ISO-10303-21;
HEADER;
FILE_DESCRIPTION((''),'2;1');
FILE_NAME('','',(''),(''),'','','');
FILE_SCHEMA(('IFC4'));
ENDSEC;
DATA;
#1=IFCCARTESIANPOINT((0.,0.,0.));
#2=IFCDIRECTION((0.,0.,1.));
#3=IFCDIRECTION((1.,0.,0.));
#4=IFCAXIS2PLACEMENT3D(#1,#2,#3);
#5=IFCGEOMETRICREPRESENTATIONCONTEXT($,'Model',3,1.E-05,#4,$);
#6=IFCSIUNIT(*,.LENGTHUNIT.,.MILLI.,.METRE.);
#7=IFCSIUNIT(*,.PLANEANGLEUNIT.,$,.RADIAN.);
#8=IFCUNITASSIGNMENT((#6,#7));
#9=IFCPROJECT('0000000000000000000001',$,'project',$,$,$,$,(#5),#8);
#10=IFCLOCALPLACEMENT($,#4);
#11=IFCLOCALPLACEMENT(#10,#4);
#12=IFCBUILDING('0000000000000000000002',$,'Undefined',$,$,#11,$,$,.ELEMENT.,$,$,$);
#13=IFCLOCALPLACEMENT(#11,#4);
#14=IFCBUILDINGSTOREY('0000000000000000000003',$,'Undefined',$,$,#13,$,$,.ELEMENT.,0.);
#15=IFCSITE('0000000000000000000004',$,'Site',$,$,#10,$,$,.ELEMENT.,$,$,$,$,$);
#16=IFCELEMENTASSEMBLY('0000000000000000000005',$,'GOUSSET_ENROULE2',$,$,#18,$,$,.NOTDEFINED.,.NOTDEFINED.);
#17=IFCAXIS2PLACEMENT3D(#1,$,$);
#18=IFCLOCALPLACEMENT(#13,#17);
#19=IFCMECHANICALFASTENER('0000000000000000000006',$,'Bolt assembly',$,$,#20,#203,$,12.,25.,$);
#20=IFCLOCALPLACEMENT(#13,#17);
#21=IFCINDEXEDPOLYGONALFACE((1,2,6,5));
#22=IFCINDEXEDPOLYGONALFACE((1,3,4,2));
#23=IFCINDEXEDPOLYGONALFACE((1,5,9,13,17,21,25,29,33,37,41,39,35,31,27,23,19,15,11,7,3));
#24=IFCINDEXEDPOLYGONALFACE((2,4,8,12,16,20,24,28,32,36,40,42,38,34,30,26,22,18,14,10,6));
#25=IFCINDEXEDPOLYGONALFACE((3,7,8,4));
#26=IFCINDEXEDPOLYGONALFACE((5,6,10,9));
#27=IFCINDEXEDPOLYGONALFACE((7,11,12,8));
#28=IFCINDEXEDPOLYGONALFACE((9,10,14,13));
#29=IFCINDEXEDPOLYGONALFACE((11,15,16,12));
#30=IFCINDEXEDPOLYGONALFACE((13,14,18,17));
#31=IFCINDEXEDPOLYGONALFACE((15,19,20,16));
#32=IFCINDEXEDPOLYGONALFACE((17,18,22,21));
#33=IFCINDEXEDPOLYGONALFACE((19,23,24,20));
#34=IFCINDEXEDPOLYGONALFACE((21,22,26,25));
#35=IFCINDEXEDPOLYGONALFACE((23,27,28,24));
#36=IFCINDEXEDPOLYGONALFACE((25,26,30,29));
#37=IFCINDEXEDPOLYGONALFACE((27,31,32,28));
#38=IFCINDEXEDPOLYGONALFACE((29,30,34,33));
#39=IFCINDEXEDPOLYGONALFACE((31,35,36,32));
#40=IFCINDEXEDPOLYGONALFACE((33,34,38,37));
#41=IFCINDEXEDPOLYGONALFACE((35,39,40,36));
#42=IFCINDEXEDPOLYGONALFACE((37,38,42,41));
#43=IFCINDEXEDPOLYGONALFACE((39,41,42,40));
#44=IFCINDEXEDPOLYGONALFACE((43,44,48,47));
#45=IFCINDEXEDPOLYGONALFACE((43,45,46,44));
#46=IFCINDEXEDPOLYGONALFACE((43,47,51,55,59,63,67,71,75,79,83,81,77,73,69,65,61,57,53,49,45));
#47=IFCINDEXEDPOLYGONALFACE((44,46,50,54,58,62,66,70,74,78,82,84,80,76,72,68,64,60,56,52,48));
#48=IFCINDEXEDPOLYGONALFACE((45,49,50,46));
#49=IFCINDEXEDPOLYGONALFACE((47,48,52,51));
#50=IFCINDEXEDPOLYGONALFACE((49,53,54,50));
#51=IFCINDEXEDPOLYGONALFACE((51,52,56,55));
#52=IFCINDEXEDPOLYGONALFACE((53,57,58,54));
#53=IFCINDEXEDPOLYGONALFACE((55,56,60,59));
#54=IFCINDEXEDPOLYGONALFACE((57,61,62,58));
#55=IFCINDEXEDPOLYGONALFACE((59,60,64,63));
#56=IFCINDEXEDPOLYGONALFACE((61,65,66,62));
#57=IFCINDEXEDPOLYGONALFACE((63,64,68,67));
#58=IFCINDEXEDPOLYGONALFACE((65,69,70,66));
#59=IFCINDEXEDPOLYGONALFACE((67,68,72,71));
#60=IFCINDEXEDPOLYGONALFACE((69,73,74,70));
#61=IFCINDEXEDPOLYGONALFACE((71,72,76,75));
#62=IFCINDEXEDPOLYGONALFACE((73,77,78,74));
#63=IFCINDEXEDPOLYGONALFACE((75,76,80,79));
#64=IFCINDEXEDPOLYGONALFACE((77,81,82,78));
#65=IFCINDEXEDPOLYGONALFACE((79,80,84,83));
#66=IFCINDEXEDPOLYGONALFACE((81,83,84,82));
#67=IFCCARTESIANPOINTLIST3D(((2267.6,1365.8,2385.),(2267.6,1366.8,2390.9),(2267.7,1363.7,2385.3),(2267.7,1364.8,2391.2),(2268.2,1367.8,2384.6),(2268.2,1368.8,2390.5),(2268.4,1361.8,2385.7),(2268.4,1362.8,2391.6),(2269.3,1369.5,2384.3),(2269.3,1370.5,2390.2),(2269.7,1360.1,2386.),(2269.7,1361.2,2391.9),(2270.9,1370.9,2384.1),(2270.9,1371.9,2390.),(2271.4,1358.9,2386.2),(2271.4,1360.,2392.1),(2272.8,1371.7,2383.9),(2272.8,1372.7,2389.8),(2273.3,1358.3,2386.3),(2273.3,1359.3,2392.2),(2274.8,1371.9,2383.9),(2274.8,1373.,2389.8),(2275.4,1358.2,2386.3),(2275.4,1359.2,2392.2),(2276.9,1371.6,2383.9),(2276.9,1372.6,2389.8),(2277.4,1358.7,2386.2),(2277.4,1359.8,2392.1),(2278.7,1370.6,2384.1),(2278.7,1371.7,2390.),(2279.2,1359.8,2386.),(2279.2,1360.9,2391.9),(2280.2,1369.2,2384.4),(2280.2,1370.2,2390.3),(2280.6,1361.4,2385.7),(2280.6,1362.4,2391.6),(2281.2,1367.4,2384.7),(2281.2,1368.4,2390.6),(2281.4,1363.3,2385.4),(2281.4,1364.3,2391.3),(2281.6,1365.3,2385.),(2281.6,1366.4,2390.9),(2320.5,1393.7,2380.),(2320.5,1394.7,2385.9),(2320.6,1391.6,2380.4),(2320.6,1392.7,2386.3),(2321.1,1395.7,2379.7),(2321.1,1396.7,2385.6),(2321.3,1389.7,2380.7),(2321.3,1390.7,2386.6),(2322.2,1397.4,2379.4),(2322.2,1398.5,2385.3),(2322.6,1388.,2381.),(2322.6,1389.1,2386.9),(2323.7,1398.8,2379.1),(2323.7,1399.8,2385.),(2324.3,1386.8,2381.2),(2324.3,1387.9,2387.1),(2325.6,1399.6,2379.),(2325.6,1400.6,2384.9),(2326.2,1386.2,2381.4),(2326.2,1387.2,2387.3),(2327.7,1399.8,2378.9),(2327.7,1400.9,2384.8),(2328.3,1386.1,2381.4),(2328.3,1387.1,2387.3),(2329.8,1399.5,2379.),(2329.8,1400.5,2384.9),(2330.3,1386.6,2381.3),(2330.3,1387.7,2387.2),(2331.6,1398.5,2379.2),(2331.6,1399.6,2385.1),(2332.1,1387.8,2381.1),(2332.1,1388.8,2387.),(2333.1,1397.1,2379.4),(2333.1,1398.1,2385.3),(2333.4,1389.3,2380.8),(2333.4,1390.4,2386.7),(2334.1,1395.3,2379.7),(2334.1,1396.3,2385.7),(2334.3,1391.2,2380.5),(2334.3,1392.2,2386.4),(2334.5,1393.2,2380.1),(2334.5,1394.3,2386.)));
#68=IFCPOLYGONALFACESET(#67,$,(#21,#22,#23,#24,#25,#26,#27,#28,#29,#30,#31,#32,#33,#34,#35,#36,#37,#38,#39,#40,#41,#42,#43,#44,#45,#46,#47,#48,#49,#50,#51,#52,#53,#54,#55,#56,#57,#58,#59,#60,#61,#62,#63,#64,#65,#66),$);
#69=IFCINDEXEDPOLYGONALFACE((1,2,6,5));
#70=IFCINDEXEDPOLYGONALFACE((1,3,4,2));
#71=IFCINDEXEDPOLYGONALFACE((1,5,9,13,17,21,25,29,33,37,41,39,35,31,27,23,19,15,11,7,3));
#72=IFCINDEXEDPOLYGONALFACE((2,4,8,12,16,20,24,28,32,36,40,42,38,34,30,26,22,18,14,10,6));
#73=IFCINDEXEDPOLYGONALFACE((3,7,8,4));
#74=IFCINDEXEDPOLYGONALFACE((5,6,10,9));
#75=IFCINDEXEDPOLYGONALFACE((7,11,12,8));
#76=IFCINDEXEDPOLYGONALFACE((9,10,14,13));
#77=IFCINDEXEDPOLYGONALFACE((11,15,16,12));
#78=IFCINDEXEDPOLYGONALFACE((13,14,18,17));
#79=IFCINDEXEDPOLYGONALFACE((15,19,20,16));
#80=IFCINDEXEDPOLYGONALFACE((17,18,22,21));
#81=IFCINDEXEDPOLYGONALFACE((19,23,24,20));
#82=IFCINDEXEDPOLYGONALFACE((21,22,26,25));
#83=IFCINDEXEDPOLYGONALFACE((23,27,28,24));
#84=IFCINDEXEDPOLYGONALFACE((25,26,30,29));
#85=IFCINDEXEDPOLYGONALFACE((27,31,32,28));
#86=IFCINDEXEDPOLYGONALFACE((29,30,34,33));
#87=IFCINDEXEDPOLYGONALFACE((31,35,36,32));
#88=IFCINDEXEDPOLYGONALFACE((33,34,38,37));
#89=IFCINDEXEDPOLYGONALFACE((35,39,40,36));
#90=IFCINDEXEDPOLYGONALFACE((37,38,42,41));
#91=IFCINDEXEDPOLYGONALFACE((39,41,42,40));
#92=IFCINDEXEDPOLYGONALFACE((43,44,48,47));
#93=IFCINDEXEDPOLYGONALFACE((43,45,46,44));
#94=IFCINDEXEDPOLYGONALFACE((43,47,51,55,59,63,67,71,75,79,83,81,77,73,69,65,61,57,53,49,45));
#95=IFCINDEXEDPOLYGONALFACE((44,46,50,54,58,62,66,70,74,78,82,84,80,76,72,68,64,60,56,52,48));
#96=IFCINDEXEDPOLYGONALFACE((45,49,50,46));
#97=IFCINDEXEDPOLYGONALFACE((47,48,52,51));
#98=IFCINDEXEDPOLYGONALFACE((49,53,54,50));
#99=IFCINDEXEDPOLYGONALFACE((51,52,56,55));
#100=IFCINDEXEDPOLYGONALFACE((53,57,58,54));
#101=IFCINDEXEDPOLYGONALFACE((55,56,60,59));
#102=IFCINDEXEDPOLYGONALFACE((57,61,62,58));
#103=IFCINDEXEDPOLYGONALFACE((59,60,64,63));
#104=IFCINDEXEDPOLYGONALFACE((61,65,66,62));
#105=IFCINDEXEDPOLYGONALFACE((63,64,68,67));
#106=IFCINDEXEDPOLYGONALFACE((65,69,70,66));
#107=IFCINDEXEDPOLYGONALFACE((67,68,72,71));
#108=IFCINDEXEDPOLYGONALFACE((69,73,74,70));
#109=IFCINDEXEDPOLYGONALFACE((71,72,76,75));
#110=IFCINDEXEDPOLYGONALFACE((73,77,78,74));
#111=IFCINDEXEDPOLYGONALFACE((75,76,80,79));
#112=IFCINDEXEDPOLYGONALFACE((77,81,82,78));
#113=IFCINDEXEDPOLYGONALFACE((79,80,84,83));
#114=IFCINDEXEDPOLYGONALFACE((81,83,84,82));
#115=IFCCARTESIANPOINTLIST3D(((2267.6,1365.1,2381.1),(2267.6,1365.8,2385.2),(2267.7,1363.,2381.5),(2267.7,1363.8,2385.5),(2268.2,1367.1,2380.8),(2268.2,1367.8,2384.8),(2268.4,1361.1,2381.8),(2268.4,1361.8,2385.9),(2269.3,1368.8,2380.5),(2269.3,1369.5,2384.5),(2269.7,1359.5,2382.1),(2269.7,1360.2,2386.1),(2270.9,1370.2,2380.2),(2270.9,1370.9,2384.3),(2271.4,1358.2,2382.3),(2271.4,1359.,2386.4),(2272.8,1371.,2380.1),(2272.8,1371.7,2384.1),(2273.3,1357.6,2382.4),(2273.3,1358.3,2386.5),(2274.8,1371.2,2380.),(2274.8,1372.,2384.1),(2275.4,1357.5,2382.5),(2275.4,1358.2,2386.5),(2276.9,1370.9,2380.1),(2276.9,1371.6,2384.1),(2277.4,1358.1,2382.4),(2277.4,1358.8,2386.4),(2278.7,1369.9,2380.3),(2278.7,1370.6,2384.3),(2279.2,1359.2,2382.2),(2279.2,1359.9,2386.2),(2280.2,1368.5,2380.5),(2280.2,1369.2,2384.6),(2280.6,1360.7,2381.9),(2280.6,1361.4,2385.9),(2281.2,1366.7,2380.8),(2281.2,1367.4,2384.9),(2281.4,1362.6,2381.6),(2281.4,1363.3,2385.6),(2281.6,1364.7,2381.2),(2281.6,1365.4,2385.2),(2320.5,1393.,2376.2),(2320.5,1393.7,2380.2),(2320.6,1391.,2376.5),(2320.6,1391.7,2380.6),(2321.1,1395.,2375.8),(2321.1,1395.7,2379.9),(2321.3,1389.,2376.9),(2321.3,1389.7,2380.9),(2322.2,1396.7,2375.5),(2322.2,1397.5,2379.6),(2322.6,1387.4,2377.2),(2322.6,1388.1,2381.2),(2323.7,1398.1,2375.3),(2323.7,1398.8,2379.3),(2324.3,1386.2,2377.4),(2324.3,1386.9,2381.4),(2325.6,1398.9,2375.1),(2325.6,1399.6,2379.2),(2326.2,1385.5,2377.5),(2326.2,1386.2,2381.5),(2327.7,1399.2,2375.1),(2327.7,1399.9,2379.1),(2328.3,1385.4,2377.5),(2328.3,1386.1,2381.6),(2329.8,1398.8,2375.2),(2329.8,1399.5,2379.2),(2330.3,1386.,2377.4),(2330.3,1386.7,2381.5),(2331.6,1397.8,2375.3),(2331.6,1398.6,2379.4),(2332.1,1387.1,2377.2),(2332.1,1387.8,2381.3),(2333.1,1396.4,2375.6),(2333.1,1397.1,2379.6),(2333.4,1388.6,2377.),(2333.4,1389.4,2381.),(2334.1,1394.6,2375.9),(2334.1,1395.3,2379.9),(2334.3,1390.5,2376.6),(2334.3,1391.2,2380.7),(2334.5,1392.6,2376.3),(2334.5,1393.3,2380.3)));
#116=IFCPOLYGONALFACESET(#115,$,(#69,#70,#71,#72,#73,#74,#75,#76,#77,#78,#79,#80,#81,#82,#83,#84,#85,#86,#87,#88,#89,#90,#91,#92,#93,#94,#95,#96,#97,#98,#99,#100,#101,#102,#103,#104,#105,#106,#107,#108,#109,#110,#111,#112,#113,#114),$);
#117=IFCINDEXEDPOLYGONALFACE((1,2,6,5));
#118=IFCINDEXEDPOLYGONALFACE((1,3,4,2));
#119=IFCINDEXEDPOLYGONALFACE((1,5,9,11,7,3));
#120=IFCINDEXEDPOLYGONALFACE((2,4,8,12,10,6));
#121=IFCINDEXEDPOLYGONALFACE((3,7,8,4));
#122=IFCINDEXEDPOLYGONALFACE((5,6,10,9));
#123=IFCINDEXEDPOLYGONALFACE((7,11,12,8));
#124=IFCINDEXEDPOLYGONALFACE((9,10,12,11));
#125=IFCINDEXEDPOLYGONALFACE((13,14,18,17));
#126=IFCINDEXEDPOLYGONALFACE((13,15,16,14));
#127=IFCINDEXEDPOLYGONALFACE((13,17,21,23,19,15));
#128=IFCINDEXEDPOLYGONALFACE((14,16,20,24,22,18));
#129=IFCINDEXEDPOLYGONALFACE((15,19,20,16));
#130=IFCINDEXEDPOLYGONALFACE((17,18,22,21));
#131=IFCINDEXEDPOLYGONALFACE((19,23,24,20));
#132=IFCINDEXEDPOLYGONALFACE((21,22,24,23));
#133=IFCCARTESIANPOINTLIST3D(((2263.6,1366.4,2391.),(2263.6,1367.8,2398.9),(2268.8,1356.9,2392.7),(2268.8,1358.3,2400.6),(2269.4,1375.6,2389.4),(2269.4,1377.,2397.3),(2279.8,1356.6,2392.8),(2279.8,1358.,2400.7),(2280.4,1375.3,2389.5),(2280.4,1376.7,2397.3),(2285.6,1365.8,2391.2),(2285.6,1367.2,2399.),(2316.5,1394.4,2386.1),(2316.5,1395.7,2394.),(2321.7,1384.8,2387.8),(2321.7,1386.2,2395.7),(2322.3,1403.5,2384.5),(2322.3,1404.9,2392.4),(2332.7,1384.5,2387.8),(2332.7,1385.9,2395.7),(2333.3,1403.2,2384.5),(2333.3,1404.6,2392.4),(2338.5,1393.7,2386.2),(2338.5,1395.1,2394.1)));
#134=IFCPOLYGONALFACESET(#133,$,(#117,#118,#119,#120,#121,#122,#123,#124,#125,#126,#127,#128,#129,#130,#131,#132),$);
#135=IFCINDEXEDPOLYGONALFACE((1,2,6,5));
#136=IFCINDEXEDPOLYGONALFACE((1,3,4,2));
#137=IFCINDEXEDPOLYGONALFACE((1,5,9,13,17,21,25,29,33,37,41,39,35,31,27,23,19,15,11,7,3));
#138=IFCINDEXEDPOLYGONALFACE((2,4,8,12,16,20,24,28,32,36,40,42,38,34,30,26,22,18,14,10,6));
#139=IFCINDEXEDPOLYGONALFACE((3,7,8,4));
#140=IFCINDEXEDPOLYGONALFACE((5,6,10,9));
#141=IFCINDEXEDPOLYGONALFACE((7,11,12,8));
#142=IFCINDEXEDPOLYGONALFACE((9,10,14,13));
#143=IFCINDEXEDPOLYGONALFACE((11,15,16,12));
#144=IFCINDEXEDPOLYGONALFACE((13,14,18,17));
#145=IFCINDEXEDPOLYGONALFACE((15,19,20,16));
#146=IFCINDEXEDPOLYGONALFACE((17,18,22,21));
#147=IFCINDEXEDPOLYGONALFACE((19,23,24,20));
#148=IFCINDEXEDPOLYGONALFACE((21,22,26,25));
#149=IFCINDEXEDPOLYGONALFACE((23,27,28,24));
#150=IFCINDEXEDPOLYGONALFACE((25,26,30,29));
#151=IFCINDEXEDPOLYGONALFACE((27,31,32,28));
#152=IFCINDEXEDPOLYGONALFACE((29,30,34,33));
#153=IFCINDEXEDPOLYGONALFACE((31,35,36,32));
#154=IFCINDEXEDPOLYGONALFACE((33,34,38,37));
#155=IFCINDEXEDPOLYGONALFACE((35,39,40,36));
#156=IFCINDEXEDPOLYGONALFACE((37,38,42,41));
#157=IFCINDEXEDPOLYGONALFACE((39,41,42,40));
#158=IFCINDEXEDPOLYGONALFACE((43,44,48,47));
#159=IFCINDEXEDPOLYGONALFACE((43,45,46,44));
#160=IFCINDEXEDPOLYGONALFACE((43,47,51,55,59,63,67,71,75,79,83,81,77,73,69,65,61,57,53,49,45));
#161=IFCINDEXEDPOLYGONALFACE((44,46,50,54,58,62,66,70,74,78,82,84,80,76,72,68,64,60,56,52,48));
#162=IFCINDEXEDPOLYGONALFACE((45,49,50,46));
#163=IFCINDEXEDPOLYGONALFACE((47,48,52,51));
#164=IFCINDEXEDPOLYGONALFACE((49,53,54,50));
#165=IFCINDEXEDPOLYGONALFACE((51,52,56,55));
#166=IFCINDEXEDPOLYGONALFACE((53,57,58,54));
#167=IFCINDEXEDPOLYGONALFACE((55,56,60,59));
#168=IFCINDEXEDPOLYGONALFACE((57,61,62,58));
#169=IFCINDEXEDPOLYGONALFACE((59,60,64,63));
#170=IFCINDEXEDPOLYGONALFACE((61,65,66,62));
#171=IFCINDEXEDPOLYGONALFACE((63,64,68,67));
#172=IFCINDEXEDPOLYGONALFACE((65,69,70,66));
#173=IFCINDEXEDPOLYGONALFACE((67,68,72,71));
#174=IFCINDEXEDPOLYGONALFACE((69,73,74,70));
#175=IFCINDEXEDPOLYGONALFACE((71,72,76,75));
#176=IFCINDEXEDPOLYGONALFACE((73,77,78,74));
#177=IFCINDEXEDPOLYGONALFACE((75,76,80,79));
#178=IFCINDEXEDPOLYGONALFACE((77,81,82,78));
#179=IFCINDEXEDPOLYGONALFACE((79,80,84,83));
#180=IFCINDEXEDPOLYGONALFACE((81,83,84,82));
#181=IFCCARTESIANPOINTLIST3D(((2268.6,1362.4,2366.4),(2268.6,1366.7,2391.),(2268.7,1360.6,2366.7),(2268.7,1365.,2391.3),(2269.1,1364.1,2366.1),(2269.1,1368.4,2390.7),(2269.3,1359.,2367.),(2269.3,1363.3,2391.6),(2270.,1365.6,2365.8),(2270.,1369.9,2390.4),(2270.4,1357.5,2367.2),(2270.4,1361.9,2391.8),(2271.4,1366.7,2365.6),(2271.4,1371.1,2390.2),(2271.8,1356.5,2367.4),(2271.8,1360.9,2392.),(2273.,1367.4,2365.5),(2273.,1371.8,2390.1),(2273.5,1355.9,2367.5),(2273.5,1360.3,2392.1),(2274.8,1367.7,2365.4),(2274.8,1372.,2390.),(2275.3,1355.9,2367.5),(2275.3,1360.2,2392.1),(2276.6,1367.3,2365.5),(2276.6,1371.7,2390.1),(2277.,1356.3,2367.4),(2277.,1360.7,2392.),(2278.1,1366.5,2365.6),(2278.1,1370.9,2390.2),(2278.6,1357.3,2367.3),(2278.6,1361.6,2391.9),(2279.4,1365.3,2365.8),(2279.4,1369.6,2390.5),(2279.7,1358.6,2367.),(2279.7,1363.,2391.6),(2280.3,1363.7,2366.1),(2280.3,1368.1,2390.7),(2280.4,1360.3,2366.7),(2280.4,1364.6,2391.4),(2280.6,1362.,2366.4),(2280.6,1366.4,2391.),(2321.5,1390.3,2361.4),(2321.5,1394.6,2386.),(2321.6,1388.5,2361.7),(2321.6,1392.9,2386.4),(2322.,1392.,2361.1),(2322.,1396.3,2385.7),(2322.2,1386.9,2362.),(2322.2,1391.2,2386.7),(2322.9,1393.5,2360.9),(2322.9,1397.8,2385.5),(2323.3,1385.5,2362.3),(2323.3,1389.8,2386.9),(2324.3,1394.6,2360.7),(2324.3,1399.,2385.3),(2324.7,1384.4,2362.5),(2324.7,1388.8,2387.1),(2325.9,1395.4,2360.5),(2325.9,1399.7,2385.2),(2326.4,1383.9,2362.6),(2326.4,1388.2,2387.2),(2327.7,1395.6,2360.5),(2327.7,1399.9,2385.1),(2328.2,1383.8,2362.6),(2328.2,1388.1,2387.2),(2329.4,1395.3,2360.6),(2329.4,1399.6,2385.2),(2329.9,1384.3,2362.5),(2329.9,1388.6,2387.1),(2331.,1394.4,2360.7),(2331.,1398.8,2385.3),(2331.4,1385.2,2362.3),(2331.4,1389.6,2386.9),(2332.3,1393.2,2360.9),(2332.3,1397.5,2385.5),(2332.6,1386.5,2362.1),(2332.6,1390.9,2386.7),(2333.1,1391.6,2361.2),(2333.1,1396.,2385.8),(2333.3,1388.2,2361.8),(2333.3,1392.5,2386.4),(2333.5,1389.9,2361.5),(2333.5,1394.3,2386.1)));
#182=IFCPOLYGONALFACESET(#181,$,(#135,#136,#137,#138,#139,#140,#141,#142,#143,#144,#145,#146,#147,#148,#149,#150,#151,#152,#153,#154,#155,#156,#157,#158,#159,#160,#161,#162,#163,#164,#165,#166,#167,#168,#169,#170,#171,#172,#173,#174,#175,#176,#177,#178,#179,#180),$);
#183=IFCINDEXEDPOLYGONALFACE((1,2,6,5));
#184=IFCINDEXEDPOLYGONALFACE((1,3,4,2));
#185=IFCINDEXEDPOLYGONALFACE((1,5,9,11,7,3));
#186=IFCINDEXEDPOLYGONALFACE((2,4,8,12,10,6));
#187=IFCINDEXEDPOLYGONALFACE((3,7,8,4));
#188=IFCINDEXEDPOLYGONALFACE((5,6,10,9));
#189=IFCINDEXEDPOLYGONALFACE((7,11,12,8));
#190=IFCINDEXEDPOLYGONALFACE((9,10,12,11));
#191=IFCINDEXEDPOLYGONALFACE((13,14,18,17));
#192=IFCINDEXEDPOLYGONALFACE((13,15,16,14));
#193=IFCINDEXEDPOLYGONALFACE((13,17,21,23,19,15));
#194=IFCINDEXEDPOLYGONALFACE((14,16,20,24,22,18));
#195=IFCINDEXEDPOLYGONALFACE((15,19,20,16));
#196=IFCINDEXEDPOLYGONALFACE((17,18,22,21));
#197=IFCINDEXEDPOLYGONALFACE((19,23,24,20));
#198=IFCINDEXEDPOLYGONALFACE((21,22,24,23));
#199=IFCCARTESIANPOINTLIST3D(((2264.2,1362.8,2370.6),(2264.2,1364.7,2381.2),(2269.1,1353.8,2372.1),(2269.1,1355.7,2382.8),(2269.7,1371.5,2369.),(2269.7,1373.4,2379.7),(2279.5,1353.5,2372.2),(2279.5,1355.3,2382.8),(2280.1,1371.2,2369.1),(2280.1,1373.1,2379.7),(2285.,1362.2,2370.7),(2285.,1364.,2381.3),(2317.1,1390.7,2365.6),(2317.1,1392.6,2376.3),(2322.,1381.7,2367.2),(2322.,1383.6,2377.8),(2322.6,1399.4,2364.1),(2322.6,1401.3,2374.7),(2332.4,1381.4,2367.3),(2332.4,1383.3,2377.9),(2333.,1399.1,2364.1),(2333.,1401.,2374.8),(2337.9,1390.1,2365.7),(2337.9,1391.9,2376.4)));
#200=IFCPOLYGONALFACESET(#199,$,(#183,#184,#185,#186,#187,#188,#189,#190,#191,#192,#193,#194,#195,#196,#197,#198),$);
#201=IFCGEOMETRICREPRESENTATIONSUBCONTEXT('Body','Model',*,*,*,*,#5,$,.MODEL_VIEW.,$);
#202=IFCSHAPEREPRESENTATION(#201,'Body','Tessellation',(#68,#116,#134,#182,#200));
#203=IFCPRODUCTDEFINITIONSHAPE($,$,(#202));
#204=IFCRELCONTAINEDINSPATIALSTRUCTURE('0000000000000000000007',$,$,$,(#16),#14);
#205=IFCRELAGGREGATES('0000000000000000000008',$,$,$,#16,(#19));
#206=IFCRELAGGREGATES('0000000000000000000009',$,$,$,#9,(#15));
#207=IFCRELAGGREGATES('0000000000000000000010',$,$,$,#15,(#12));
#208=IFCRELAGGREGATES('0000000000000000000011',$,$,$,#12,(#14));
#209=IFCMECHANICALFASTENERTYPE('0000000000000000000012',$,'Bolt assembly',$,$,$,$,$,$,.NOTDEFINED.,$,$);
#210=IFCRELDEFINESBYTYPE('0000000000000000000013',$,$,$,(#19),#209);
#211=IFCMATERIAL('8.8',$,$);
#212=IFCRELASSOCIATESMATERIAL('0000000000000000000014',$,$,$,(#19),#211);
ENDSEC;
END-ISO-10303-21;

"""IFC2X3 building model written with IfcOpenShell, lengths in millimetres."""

from ifc_helpers import new_model, si_unit, frame, origin_with_axes, origin_2d_with_axis, place, context, subcontext, project, spatial, polyline, circle, outline, extrude, source, transform, mapped, material, type_object, element, aggregate, save


model = new_model("IFC2X3")

# Units and contexts
model_context = context("Model", 3, precision=1e-05, world=origin_with_axes())
body_context = subcontext(model_context, "Body", "Model", "MODEL_VIEW")
ifc_project = project(units=[si_unit("LENGTHUNIT", "METRE", prefix="MILLI"), si_unit("PLANEANGLEUNIT", "RADIAN")], contexts=[model_context])

# Site, building, storey
site_placement = place(None, origin_with_axes())
site = spatial("IfcSite", under=ifc_project, at=site_placement, Name="Site", CompositionType="ELEMENT")
building_placement = place(site_placement, origin_with_axes())
building = spatial("IfcBuilding", under=site, at=building_placement, Name="Undefined", CompositionType="ELEMENT")
storey_placement = place(building_placement, origin_with_axes())
storey = spatial("IfcBuildingStorey", under=building, at=storey_placement, Name="Undefined", CompositionType="ELEMENT", Elevation=0.0)

# Shared definitions
ifc_material_1 = material(Name="8.8")
mechanical_fastener_type = type_object("IfcMechanicalFastenerType", Name="Bolt assembly")

# Element assembly
assembly_1_placement = place(storey_placement, origin_with_axes())
assembly_1 = element("IfcElementAssembly", 1, at=assembly_1_placement, inside=storey, Name="GOUSSET_ENROULE2", AssemblyPlace="NOTDEFINED", PredefinedType="NOTDEFINED")

# Mechanical fastener
shared_shape_1 = source(origin_with_axes(), body_context, "Body", "SweptSolid", [
    extrude(circle(Radius=7.0, at=origin_2d_with_axis()), frame((0.0, -35.9, 0.0), z_axis=(0.0, 1.0, 0.0), x_axis=(1.0, 0.0, 0.0)), (0.0, 0.0, 1.0), 6.0),
    extrude(circle(Radius=7.0, at=origin_2d_with_axis()), frame((0.0, -30.1, 0.0), z_axis=(0.0, 1.0, 0.0), x_axis=(1.0, 0.0, 0.0)), (0.0, 0.0, 1.0), 4.1),
    extrude(outline(polyline([(9.5, -5.5), (9.5, 5.5), (0.0, 11.0), (-9.5, 5.5), (-9.5, -5.5), (0.0, -11.0), (9.5, -5.5)])), frame((0.0, -44.0, 0.0), z_axis=(0.0, 1.0, 0.0), x_axis=(1.0, 0.0, 0.0)), (0.0, 0.0, 1.0), 8.0),
    extrude(circle(Radius=6.0, at=origin_2d_with_axis()), frame((0.0, -36.0, 0.0), z_axis=(0.0, 1.0, 0.0), x_axis=(1.0, 0.0, 0.0)), (0.0, 0.0, 1.0), 25.0),
    extrude(outline(polyline([(9.0, -5.2), (9.0, 5.2), (0.0, 10.4), (-9.0, 5.2), (-9.0, -5.2), (0.0, -10.4), (9.0, -5.2)])), frame((0.0, -26.0, 0.0), z_axis=(0.0, 1.0, 0.0), x_axis=(1.0, 0.0, 0.0)), (0.0, 0.0, 1.0), 10.8),
])
mechanical_fastener_1_placement = place(assembly_1_placement, frame((2327.5, 1387.7, 2350.7), z_axis=(0.472417, -0.867927, 0.153376), x_axis=(-0.881375, -0.465209, 0.08221)))
mechanical_fastener_1 = element("IfcMechanicalFastener", 2, at=mechanical_fastener_1_placement, type_object=mechanical_fastener_type, material=ifc_material_1, Name="Bolt assembly", NominalDiameter=12.0, NominalLength=25.0, context=body_context, shape_type="MappedRepresentation", body=[
    mapped(shared_shape_1, transform((0.0, 0.0, 0.0))),
    mapped(shared_shape_1, transform((60.0, 0.0, 0.0))),
])
aggregate(assembly_1, [mechanical_fastener_1])

save(model, "model.ifc")
